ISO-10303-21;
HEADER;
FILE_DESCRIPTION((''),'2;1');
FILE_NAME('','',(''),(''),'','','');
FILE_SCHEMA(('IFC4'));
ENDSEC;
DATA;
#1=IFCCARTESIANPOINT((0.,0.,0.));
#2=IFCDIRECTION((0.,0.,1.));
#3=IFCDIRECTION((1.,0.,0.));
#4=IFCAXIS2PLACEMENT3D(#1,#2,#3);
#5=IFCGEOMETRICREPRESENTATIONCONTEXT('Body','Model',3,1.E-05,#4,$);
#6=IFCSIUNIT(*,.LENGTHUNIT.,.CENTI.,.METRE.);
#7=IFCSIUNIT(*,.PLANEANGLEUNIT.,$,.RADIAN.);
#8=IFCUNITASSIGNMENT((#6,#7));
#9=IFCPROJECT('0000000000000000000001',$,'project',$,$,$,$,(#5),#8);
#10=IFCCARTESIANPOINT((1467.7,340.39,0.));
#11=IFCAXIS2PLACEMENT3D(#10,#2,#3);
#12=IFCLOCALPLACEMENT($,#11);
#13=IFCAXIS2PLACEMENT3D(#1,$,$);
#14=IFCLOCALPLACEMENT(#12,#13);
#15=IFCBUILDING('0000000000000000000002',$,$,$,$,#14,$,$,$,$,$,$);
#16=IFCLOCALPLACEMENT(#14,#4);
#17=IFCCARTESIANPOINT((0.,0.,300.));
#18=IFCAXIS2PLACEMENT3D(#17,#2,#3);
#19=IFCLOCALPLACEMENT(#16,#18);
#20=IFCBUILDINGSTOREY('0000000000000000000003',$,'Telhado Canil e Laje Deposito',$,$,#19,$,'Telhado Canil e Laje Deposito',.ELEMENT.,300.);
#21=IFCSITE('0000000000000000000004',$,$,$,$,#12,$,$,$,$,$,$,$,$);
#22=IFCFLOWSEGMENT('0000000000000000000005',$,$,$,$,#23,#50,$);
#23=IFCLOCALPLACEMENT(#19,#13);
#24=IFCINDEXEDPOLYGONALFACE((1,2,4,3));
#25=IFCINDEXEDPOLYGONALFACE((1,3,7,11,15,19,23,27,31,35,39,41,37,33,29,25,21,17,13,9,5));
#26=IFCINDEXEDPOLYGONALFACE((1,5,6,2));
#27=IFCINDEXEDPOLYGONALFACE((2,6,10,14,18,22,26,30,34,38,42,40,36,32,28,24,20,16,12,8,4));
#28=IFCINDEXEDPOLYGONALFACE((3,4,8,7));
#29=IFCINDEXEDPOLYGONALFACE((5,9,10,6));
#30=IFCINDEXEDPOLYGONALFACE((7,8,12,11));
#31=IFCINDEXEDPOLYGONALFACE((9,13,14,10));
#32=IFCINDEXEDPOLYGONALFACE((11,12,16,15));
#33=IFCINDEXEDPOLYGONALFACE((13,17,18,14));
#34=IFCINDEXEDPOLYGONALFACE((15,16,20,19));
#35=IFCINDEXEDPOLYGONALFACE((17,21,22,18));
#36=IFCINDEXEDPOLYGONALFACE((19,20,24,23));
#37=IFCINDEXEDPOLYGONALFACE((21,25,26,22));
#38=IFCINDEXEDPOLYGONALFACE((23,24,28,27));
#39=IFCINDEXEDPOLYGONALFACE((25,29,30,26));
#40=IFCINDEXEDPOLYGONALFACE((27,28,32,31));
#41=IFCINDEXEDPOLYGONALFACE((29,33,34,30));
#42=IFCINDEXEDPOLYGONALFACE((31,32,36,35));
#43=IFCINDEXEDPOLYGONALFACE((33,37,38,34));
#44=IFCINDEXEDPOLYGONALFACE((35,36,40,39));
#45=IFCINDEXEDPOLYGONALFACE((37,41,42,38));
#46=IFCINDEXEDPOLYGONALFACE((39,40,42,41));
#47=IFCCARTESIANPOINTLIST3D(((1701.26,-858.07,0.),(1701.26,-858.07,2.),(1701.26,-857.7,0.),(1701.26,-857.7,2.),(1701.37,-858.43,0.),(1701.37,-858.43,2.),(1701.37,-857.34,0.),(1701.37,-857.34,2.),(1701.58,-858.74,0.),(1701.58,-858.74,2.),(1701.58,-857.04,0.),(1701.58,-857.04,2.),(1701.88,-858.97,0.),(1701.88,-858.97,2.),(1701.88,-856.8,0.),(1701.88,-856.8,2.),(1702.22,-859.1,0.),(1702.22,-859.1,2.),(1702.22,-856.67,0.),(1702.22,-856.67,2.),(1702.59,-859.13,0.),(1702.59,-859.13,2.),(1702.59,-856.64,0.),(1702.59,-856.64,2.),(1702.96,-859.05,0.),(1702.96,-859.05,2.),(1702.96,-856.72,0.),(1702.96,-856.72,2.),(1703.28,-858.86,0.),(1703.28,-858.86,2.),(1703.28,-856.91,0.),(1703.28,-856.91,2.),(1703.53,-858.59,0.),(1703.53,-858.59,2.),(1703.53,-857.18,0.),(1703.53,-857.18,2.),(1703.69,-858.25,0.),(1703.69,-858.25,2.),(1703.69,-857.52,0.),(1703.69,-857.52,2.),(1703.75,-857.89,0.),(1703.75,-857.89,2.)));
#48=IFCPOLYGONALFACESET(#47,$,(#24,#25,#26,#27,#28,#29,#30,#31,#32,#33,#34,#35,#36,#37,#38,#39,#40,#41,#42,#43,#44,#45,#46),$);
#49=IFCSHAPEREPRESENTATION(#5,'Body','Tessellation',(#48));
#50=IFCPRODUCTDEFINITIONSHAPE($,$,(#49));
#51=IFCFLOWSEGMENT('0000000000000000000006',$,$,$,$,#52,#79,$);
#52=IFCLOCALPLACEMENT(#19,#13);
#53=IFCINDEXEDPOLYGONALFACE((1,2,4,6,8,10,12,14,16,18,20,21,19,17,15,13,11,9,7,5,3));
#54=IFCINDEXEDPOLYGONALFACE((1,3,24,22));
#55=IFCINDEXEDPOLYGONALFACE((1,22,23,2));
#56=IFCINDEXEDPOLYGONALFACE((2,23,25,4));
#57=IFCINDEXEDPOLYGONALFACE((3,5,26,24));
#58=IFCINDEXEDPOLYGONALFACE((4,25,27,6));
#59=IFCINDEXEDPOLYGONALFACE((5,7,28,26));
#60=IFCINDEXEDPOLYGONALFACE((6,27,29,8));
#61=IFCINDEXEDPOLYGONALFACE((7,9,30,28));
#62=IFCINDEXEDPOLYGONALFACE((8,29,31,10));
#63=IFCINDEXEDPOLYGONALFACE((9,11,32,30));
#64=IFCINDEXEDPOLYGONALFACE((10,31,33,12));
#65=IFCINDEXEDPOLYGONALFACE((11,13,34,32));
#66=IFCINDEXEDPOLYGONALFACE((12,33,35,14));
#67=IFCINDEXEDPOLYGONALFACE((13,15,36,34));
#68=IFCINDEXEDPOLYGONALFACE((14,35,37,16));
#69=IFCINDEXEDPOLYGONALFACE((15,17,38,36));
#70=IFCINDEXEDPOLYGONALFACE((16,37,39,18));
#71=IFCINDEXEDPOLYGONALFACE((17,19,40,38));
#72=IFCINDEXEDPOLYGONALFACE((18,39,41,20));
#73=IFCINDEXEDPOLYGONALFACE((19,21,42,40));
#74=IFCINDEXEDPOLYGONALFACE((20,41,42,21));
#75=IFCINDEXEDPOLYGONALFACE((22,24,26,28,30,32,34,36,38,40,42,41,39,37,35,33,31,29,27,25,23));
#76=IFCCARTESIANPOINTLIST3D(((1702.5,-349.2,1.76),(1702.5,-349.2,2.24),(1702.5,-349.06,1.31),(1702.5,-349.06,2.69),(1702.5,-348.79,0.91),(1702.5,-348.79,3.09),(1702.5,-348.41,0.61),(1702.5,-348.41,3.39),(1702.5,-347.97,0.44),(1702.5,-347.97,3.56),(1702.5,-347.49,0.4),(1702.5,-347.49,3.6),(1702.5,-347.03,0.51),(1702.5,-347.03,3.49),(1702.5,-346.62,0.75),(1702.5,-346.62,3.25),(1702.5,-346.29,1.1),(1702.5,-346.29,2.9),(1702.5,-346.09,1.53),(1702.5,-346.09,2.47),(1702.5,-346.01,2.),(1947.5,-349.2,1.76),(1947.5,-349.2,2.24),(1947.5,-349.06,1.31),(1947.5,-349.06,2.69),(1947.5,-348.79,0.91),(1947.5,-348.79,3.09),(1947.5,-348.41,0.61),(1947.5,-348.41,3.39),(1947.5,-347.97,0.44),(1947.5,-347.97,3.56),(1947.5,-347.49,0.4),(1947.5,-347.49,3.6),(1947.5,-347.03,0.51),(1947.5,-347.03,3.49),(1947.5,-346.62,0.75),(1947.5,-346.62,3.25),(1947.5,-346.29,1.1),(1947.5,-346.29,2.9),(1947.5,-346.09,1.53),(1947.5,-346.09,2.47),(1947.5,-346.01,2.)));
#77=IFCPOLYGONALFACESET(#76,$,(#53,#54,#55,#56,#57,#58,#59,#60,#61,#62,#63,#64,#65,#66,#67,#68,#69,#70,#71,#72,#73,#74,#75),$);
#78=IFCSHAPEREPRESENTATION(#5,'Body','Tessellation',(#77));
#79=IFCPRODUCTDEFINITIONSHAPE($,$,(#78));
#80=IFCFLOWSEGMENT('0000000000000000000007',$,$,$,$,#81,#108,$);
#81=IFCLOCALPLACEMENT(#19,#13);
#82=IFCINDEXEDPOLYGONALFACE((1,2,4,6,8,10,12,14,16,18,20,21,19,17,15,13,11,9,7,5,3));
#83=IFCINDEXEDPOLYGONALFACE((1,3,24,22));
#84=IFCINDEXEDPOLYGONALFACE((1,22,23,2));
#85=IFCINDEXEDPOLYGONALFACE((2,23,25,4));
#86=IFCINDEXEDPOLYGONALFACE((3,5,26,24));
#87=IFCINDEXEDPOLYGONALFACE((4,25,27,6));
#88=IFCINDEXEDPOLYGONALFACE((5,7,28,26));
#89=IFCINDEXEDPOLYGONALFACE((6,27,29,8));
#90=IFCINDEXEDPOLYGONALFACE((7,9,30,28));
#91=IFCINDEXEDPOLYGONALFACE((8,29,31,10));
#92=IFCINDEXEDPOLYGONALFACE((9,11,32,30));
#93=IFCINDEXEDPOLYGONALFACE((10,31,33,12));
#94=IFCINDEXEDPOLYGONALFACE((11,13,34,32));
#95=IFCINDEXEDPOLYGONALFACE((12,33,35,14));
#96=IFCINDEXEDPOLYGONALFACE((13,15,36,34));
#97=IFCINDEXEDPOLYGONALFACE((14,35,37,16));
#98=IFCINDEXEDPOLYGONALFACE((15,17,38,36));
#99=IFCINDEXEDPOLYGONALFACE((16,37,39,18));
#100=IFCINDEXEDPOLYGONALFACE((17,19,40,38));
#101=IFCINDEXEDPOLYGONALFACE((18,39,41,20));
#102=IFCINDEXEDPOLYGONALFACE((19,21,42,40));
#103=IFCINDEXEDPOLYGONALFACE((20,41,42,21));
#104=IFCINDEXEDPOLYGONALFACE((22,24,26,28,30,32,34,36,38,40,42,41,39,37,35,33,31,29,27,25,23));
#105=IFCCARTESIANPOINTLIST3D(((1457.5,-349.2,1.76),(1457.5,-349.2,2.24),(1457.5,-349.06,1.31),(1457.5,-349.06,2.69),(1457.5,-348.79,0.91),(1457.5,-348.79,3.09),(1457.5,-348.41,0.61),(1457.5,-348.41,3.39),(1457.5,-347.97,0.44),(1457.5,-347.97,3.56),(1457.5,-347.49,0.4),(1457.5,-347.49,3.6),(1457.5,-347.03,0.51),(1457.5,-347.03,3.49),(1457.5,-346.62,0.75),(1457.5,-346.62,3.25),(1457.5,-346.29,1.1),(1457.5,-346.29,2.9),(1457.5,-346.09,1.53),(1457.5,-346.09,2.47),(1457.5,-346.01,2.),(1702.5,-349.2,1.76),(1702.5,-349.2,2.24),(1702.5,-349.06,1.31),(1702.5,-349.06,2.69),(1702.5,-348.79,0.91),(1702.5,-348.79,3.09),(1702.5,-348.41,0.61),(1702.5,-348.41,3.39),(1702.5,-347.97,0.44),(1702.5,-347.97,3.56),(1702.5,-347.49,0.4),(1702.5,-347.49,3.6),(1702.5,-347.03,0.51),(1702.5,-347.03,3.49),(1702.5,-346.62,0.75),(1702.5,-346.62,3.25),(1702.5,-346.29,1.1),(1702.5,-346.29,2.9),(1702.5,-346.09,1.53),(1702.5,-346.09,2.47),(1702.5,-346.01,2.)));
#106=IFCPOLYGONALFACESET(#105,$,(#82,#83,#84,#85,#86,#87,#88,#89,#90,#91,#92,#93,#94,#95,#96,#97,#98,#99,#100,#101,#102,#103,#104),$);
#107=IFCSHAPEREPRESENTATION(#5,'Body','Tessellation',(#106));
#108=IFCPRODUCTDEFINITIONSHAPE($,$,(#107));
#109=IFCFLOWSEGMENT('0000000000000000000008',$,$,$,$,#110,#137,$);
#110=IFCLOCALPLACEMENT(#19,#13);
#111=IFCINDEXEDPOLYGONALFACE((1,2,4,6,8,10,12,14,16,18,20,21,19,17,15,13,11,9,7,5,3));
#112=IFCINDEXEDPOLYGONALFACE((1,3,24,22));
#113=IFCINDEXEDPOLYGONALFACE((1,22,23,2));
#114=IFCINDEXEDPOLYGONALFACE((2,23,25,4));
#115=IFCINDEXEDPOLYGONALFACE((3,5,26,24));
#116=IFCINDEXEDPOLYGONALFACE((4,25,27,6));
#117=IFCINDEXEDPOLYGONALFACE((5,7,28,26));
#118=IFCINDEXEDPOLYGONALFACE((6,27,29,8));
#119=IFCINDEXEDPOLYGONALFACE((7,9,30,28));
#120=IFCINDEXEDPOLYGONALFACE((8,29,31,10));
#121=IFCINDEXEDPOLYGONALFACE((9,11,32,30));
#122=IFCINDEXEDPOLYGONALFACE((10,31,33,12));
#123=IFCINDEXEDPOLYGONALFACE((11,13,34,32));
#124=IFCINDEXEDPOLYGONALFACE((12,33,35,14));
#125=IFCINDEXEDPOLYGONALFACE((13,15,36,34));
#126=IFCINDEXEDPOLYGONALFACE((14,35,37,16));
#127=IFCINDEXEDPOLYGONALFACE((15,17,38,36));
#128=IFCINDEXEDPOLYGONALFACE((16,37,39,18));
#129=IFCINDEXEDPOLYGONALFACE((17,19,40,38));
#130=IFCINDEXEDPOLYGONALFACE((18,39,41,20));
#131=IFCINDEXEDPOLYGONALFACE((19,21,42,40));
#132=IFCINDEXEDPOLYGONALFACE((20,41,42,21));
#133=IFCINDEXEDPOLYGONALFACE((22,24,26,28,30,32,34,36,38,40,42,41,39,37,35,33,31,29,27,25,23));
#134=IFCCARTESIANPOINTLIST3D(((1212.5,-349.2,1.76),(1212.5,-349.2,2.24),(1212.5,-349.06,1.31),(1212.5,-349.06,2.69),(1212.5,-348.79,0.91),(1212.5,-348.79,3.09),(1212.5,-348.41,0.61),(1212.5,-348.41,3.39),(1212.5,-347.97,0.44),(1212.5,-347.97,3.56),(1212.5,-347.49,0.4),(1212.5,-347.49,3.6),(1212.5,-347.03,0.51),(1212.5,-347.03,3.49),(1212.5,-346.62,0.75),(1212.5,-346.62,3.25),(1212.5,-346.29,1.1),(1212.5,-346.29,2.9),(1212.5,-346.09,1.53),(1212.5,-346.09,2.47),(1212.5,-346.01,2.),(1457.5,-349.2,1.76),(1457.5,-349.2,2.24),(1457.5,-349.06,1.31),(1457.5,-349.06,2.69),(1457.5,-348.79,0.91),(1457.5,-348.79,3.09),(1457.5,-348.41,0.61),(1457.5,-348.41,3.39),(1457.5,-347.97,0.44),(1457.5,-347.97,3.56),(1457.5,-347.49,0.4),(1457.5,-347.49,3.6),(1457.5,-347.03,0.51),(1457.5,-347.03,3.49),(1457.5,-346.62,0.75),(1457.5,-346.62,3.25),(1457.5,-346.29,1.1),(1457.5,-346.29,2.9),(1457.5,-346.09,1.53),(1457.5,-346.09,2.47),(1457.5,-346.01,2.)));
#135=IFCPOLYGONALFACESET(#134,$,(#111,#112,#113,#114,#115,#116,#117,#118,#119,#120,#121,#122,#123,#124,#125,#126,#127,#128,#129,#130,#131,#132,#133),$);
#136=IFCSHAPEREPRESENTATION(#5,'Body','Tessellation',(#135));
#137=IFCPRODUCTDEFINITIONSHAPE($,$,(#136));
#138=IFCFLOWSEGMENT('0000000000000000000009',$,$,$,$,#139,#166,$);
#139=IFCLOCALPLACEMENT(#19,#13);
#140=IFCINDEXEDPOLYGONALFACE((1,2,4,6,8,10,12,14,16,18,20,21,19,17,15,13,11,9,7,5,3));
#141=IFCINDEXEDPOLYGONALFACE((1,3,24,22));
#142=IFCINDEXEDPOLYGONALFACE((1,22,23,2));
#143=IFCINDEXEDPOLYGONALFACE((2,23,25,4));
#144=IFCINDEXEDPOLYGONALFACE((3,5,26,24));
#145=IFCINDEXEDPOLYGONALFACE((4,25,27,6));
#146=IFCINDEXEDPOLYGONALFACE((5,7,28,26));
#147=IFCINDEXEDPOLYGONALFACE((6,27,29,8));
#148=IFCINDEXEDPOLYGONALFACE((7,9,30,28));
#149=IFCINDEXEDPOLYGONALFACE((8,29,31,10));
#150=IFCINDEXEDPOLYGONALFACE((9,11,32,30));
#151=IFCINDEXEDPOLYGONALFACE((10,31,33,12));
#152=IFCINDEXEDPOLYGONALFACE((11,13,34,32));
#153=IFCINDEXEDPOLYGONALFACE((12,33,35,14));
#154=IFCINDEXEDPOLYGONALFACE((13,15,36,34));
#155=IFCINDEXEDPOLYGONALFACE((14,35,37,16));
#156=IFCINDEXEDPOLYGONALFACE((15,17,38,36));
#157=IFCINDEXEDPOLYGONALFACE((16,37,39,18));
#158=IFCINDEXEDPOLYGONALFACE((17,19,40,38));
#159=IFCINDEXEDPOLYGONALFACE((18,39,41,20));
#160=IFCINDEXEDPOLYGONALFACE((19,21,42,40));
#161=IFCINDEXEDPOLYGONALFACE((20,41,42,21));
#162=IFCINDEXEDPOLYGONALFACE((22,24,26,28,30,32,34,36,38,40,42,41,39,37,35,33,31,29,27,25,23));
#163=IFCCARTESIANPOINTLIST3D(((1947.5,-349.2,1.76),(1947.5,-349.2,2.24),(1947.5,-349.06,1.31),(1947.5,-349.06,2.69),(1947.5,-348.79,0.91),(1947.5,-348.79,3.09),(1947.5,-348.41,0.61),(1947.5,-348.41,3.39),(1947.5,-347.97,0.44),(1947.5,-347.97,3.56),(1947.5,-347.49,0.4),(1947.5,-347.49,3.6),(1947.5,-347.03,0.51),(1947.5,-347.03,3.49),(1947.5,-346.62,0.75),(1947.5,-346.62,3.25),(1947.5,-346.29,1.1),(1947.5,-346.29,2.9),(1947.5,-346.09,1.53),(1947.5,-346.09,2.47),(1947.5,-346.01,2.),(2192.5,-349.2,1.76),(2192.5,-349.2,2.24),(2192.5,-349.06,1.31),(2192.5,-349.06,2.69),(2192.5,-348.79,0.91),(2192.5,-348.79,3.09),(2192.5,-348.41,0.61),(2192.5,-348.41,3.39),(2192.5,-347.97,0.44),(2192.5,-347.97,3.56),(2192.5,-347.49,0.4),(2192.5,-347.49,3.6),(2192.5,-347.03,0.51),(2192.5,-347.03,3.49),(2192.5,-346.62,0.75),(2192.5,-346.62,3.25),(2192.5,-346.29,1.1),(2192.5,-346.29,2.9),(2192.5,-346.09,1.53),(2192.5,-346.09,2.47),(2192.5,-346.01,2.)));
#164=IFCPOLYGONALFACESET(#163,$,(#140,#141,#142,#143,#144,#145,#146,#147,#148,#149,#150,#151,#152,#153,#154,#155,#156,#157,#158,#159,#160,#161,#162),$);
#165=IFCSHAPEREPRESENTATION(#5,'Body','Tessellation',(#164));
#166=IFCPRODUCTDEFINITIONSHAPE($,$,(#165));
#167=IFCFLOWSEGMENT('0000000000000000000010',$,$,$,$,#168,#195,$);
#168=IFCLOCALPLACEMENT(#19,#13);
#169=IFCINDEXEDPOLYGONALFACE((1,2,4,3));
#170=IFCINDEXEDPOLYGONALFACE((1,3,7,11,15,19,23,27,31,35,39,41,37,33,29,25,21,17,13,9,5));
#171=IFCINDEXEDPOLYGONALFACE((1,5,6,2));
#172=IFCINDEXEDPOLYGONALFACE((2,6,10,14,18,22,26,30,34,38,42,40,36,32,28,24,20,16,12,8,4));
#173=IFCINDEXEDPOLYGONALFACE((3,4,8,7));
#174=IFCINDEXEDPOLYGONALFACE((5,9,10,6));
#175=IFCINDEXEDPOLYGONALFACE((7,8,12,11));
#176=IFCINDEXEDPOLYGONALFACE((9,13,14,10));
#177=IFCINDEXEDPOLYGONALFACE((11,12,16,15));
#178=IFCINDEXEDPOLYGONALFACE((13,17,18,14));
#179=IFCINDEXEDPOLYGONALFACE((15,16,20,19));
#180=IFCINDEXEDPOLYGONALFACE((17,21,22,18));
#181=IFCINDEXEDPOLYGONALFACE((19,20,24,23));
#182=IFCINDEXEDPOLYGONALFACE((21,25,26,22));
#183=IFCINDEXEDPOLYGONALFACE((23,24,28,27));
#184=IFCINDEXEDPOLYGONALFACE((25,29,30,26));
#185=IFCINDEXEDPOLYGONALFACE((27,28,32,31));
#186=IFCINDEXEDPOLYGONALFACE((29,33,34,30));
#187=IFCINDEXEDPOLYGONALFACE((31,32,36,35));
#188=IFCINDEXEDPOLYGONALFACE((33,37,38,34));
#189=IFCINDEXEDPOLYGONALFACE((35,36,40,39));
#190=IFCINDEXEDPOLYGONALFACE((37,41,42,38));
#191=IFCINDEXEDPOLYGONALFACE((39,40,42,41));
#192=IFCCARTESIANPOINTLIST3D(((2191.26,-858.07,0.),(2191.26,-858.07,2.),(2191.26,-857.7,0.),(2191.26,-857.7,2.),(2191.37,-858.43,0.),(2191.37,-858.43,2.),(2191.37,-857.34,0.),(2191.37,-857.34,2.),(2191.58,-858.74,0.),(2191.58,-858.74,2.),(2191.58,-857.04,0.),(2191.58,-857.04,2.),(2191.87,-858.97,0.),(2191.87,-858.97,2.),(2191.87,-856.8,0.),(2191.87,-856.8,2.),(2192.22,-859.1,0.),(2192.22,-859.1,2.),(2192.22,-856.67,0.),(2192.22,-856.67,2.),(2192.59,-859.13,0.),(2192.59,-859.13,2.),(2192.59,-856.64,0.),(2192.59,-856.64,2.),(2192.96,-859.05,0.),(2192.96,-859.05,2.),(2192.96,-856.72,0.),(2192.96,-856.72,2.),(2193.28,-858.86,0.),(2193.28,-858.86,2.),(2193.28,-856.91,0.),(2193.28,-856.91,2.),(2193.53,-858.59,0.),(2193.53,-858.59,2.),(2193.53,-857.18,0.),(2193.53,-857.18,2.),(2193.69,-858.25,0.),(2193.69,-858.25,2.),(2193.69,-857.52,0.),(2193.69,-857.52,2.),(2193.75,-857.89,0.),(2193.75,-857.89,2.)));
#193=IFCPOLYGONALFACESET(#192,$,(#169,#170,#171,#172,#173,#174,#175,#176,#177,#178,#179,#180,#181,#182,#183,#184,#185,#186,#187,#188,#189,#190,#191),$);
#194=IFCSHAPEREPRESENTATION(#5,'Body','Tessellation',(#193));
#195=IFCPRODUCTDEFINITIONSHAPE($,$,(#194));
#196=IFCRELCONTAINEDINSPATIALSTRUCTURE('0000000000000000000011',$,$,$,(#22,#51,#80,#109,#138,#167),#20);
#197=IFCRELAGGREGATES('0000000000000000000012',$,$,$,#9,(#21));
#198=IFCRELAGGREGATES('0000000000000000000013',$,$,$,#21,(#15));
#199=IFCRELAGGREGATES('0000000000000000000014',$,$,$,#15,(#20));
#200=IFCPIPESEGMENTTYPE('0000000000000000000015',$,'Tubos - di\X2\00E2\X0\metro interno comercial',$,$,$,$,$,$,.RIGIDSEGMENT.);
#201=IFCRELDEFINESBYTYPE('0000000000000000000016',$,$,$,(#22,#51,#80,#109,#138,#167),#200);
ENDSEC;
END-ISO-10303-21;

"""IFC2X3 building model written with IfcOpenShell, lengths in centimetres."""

from ifc_helpers import new_model, si_unit, frame, origin, origin_with_axes, origin_2d_with_axis, place, context, project, spatial, circle, extrude, type_object, element, save


model = new_model("IFC2X3")

# Units and contexts
model_context = context("Model", 3, precision=1e-05, world=origin_with_axes(), identifier="Body")
ifc_project = project(units=[si_unit("LENGTHUNIT", "METRE", prefix="CENTI"), si_unit("PLANEANGLEUNIT", "RADIAN")], contexts=[model_context])

# Site, building, storey
site_placement = place(None, frame((1467.7, 340.39, 0.0), z_axis=(0.0, 0.0, 1.0), x_axis=(1.0, 0.0, 0.0)))
site = spatial("IfcSite", under=ifc_project, at=site_placement)
building_placement = place(site_placement, origin())
building = spatial("IfcBuilding", under=site, at=building_placement)
placement = place(building_placement, origin_with_axes())
storey_placement = place(placement, frame((0.0, 0.0, 300.0), z_axis=(0.0, 0.0, 1.0), x_axis=(1.0, 0.0, 0.0)))
storey = spatial("IfcBuildingStorey", under=building, at=storey_placement, Name="Telhado Canil e Laje Deposito", LongName="Telhado Canil e Laje Deposito", CompositionType="ELEMENT", Elevation=300.0)

# Flow segments
pipe_segment_type_1 = type_object("IfcPipeSegmentType", Name="Tubos - diâmetro interno comercial", PredefinedType="RIGIDSEGMENT")
flow_segment_1_placement = place(storey_placement, frame((1702.5, -857.89, 2.0), z_axis=(0.0, 0.0, 1.0), x_axis=(1.0, 0.0, 0.0)))
element("IfcFlowSegment", 1, at=flow_segment_1_placement, inside=storey, type_object=pipe_segment_type_1, context=model_context, shape_type="SolidModel", body=[
    extrude(circle(Radius=1.25, at=origin_2d_with_axis()), frame((0.0, 0.0, 0.0), z_axis=(0.0, 0.0, -1.0), x_axis=(1.0, 0.0, 0.0)), (0.0, 0.0, 1.0), 2.0),
])
for number, where, z_axis, x_axis in (
    (2, (1825.0, -347.61, 3.6), (0.0, 0.0, 1.0), (1.0, 0.0, 0.0)),
    (3, (1580.0, -347.61, 3.6), (0.0, 0.0, 1.0), (1.0, 0.0, 0.0)),
    (4, (1335.0, -347.61, 3.6), (0.0, 0.0, 1.0), (1.0, 0.0, 0.0)),
    (5, (2070.0, -347.61, 3.6), (0.0, 0.0, 1.0), (1.0, 0.0, 0.0)),
):
    element("IfcFlowSegment", number, at=place(storey_placement, frame(where, z_axis=z_axis, x_axis=x_axis)), inside=storey, type_object=pipe_segment_type_1, context=model_context, shape_type="SolidModel", body=[
        extrude(circle(Radius=1.6, at=origin_2d_with_axis()), frame((122.5, 0.0, -1.6), z_axis=(-1.0, 0.0, 0.0), x_axis=(0.0, 1.0, 0.0)), (0.0, 0.0, 1.0), 245.0),
    ])
for number, where, z_axis, x_axis in (
    (6, (2192.5, -857.89, 2.0), (0.0, 0.0, 1.0), (1.0, 0.0, 0.0)),
):
    element("IfcFlowSegment", number, at=place(storey_placement, frame(where, z_axis=z_axis, x_axis=x_axis)), inside=storey, type_object=pipe_segment_type_1, context=model_context, shape_type="SolidModel", body=[
        extrude(circle(Radius=1.25, at=origin_2d_with_axis()), frame((0.0, 0.0, 0.0), z_axis=(0.0, 0.0, -1.0), x_axis=(1.0, 0.0, 0.0)), (0.0, 0.0, 1.0), 2.0),
    ])

save(model, "model.ifc")
